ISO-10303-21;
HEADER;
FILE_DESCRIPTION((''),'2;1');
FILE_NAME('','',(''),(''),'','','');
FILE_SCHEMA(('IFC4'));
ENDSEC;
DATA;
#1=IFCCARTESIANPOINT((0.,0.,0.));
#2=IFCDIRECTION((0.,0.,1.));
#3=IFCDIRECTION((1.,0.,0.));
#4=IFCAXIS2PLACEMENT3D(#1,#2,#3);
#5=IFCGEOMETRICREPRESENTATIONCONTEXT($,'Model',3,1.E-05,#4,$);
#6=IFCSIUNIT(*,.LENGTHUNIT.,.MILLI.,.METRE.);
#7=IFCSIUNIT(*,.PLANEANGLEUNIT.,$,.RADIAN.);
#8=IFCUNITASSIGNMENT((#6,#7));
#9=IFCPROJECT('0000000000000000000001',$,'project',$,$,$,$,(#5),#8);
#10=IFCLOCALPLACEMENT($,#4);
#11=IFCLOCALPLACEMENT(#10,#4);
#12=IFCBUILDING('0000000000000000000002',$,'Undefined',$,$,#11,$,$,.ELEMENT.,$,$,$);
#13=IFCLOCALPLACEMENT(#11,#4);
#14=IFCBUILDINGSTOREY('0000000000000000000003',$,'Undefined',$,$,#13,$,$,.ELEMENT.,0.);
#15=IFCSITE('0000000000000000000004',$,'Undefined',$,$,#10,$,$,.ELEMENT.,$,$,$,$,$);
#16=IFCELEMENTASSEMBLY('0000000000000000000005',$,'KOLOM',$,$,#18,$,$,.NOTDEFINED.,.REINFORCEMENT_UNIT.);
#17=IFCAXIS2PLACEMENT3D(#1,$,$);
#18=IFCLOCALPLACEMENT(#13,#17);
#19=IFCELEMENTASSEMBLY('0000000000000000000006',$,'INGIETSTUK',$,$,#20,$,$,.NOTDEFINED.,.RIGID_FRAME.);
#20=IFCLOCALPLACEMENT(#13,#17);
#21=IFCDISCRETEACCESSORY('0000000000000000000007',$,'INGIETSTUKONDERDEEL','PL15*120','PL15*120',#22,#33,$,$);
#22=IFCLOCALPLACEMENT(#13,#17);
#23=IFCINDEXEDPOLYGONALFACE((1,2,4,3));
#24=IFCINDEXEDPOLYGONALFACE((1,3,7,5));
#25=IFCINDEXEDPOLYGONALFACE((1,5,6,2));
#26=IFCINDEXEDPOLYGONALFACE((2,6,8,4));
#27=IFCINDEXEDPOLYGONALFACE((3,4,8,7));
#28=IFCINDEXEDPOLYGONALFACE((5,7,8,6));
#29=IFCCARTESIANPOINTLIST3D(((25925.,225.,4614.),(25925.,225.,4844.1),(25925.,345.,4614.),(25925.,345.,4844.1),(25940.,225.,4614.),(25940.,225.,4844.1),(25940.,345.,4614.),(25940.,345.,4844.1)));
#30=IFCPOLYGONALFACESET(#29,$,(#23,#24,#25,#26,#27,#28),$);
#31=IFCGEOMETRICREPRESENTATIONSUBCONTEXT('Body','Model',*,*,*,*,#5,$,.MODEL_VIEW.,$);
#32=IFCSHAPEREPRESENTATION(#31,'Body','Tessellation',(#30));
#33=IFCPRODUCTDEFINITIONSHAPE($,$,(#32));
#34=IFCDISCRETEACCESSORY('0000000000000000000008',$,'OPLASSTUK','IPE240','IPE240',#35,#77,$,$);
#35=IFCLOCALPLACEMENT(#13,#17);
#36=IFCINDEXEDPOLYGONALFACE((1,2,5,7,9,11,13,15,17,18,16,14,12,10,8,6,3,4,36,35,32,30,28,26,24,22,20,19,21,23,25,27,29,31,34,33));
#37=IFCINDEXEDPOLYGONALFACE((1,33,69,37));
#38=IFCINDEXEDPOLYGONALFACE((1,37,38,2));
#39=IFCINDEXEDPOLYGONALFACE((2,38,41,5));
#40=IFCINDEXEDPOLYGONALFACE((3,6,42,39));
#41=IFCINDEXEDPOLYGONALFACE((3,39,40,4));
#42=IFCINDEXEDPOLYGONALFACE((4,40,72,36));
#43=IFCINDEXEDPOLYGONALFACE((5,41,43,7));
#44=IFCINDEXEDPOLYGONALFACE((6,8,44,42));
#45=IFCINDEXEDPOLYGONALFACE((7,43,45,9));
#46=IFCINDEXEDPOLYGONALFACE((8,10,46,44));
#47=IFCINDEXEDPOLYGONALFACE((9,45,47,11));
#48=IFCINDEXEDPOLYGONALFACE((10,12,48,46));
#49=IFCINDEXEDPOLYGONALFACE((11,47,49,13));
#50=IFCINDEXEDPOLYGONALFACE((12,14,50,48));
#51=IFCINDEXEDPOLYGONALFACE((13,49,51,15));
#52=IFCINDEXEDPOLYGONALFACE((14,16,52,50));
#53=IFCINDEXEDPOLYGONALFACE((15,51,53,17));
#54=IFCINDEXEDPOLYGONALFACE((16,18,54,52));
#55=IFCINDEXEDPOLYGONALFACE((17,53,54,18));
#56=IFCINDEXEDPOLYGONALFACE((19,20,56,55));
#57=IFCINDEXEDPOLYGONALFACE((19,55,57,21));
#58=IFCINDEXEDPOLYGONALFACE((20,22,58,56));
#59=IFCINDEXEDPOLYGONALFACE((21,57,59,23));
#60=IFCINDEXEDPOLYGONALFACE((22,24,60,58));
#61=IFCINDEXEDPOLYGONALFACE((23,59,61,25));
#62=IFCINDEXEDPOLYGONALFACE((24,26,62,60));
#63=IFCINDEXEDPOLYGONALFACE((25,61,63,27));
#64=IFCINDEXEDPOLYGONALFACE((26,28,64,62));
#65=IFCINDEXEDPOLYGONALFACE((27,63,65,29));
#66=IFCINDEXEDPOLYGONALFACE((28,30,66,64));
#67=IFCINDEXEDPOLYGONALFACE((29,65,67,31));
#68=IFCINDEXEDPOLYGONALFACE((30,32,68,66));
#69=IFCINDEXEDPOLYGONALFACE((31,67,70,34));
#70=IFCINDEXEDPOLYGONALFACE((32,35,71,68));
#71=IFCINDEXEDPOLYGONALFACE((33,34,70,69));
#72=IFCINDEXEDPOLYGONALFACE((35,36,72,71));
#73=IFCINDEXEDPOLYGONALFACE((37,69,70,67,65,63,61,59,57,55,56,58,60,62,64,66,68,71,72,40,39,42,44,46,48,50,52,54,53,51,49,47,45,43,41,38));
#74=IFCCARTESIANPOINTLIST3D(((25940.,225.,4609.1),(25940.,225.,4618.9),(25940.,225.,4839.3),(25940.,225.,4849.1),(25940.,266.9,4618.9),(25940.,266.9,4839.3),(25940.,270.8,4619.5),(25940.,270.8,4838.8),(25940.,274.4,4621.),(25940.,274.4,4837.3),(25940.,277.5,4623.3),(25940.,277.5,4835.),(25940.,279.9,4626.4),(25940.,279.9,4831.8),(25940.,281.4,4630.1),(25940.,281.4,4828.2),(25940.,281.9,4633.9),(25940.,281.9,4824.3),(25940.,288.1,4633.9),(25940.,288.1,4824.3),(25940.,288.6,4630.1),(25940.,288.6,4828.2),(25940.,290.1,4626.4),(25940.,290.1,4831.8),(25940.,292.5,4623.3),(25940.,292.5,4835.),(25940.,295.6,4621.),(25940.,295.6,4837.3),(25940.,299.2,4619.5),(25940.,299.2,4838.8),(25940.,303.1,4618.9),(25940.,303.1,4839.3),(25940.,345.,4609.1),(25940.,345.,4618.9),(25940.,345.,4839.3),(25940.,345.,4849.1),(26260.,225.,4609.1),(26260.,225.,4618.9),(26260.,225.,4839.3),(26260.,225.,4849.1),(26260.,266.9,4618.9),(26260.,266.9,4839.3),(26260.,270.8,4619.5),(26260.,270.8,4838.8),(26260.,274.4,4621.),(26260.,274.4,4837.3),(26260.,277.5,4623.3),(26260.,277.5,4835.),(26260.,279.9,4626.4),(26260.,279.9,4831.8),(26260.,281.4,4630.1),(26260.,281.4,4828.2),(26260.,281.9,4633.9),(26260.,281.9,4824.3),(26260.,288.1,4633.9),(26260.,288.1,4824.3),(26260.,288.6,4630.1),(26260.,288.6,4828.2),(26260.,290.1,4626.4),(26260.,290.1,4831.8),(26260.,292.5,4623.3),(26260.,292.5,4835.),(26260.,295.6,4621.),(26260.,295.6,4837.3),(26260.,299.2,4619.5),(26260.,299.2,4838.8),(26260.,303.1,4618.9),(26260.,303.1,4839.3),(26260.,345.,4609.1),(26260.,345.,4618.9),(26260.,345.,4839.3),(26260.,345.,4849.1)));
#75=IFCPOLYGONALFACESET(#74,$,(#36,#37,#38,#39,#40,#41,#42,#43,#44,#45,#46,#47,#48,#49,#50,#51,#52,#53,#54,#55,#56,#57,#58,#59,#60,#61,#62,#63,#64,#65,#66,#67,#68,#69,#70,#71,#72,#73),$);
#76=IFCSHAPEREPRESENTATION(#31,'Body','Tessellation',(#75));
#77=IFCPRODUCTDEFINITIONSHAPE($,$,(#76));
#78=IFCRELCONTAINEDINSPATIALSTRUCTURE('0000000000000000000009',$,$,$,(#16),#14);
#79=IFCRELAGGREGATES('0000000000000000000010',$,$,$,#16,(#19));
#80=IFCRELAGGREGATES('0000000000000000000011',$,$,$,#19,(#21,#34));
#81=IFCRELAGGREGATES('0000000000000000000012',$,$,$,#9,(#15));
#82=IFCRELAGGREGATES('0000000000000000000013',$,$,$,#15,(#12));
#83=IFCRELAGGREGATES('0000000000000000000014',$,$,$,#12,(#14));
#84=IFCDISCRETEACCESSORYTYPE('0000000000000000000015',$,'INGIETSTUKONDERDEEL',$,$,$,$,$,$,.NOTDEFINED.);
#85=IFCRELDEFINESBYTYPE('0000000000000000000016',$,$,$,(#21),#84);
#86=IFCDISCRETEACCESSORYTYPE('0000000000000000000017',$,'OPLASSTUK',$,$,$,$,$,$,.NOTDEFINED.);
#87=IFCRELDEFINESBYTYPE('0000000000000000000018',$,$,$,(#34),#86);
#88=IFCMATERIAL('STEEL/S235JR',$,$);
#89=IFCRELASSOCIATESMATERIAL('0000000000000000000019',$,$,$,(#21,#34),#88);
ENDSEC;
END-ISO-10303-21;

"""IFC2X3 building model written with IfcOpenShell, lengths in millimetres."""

from ifc_helpers import new_model, si_unit, frame, frame_2d, origin_with_axes, place, context, subcontext, project, spatial, rectangle, i_section, extrude, clip, halfspace, material, type_object, element, aggregate, save


model = new_model("IFC2X3")

# Units and contexts
model_context = context("Model", 3, precision=1e-05, world=origin_with_axes())
body_context = subcontext(model_context, "Body", "Model", "MODEL_VIEW")
ifc_project = project(units=[si_unit("LENGTHUNIT", "METRE", prefix="MILLI"), si_unit("PLANEANGLEUNIT", "RADIAN")], contexts=[model_context])

# Site, building, storey
site_placement = place(None, origin_with_axes())
site = spatial("IfcSite", under=ifc_project, at=site_placement, Name="Undefined", CompositionType="ELEMENT")
building_placement = place(site_placement, origin_with_axes())
building = spatial("IfcBuilding", under=site, at=building_placement, Name="Undefined", CompositionType="ELEMENT")
storey_placement = place(building_placement, origin_with_axes())
storey = spatial("IfcBuildingStorey", under=building, at=storey_placement, Name="Undefined", CompositionType="ELEMENT", Elevation=0.0)

# Shared definitions
ifc_material_1 = material(Name="STEEL/S235JR")

# Element assemblies, discrete accessories
assembly_1_placement = place(storey_placement, origin_with_axes())
assembly_1 = element("IfcElementAssembly", 1, at=assembly_1_placement, inside=storey, Name="KOLOM", AssemblyPlace="NOTDEFINED", PredefinedType="REINFORCEMENT_UNIT")
assembly_2_placement = place(assembly_1_placement, origin_with_axes())
assembly_2 = element("IfcElementAssembly", 2, at=assembly_2_placement, Name="INGIETSTUK", AssemblyPlace="NOTDEFINED", PredefinedType="RIGID_FRAME")
aggregate(assembly_1, [assembly_2])
discrete_accessory_type_1 = type_object("IfcDiscreteAccessoryType", Name="INGIETSTUKONDERDEEL")
discrete_accessory_1_placement = place(assembly_2_placement, frame((25932.5, 285.0, 4844.1), z_axis=(0.0, -1.0, 0.0), x_axis=(0.0, 0.0, -1.0)))
discrete_accessory_1 = element("IfcDiscreteAccessory", 3, at=discrete_accessory_1_placement, type_object=discrete_accessory_type_1, material=ifc_material_1, Name="INGIETSTUKONDERDEEL", Description="PL15*120", ObjectType="PL15*120", context=body_context, shape_type="SweptSolid", body=[
    extrude(rectangle(XDim=15.0, YDim=120.0, at=frame_2d((0.0, 0.0), x_axis=(1.0, 0.0))), frame((230.1, 0.0, 0.0), z_axis=(-1.0, 0.0, 0.0), x_axis=(0.0, -1.0, 0.0)), (0.0, 0.0, 1.0), 230.1),
])
discrete_accessory_type_2 = type_object("IfcDiscreteAccessoryType", Name="OPLASSTUK")
discrete_accessory_2_placement = place(assembly_2_placement, frame((25925.0, 285.0, 4729.1), z_axis=(0.0, 0.0, 1.0), x_axis=(1.0, 0.0, 0.0)))
discrete_accessory_2 = element("IfcDiscreteAccessory", 4, at=discrete_accessory_2_placement, type_object=discrete_accessory_type_2, material=ifc_material_1, Name="OPLASSTUK", Description="IPE240", ObjectType="IPE240", context=body_context, shape_type="Clipping", body=[
    clip(extrude(i_section(OverallWidth=120.0, OverallDepth=240.0, WebThickness=6.2, FlangeThickness=9.8, FilletRadius=15.0, at=frame_2d((0.0, 0.0), x_axis=(1.0, 0.0))), frame((335.0, 0.0, 0.0), z_axis=(-1.0, 0.0, 0.0), x_axis=(0.0, -1.0, 0.0)), (0.0, 0.0, 1.0), 320.0), halfspace(frame((15.0, 0.0, -29.0), z_axis=(-1.0, 0.0, 0.0), x_axis=(0.0, -1.0, 0.0)), False)),
])
aggregate(assembly_2, [discrete_accessory_1, discrete_accessory_2])

save(model, "model.ifc")
